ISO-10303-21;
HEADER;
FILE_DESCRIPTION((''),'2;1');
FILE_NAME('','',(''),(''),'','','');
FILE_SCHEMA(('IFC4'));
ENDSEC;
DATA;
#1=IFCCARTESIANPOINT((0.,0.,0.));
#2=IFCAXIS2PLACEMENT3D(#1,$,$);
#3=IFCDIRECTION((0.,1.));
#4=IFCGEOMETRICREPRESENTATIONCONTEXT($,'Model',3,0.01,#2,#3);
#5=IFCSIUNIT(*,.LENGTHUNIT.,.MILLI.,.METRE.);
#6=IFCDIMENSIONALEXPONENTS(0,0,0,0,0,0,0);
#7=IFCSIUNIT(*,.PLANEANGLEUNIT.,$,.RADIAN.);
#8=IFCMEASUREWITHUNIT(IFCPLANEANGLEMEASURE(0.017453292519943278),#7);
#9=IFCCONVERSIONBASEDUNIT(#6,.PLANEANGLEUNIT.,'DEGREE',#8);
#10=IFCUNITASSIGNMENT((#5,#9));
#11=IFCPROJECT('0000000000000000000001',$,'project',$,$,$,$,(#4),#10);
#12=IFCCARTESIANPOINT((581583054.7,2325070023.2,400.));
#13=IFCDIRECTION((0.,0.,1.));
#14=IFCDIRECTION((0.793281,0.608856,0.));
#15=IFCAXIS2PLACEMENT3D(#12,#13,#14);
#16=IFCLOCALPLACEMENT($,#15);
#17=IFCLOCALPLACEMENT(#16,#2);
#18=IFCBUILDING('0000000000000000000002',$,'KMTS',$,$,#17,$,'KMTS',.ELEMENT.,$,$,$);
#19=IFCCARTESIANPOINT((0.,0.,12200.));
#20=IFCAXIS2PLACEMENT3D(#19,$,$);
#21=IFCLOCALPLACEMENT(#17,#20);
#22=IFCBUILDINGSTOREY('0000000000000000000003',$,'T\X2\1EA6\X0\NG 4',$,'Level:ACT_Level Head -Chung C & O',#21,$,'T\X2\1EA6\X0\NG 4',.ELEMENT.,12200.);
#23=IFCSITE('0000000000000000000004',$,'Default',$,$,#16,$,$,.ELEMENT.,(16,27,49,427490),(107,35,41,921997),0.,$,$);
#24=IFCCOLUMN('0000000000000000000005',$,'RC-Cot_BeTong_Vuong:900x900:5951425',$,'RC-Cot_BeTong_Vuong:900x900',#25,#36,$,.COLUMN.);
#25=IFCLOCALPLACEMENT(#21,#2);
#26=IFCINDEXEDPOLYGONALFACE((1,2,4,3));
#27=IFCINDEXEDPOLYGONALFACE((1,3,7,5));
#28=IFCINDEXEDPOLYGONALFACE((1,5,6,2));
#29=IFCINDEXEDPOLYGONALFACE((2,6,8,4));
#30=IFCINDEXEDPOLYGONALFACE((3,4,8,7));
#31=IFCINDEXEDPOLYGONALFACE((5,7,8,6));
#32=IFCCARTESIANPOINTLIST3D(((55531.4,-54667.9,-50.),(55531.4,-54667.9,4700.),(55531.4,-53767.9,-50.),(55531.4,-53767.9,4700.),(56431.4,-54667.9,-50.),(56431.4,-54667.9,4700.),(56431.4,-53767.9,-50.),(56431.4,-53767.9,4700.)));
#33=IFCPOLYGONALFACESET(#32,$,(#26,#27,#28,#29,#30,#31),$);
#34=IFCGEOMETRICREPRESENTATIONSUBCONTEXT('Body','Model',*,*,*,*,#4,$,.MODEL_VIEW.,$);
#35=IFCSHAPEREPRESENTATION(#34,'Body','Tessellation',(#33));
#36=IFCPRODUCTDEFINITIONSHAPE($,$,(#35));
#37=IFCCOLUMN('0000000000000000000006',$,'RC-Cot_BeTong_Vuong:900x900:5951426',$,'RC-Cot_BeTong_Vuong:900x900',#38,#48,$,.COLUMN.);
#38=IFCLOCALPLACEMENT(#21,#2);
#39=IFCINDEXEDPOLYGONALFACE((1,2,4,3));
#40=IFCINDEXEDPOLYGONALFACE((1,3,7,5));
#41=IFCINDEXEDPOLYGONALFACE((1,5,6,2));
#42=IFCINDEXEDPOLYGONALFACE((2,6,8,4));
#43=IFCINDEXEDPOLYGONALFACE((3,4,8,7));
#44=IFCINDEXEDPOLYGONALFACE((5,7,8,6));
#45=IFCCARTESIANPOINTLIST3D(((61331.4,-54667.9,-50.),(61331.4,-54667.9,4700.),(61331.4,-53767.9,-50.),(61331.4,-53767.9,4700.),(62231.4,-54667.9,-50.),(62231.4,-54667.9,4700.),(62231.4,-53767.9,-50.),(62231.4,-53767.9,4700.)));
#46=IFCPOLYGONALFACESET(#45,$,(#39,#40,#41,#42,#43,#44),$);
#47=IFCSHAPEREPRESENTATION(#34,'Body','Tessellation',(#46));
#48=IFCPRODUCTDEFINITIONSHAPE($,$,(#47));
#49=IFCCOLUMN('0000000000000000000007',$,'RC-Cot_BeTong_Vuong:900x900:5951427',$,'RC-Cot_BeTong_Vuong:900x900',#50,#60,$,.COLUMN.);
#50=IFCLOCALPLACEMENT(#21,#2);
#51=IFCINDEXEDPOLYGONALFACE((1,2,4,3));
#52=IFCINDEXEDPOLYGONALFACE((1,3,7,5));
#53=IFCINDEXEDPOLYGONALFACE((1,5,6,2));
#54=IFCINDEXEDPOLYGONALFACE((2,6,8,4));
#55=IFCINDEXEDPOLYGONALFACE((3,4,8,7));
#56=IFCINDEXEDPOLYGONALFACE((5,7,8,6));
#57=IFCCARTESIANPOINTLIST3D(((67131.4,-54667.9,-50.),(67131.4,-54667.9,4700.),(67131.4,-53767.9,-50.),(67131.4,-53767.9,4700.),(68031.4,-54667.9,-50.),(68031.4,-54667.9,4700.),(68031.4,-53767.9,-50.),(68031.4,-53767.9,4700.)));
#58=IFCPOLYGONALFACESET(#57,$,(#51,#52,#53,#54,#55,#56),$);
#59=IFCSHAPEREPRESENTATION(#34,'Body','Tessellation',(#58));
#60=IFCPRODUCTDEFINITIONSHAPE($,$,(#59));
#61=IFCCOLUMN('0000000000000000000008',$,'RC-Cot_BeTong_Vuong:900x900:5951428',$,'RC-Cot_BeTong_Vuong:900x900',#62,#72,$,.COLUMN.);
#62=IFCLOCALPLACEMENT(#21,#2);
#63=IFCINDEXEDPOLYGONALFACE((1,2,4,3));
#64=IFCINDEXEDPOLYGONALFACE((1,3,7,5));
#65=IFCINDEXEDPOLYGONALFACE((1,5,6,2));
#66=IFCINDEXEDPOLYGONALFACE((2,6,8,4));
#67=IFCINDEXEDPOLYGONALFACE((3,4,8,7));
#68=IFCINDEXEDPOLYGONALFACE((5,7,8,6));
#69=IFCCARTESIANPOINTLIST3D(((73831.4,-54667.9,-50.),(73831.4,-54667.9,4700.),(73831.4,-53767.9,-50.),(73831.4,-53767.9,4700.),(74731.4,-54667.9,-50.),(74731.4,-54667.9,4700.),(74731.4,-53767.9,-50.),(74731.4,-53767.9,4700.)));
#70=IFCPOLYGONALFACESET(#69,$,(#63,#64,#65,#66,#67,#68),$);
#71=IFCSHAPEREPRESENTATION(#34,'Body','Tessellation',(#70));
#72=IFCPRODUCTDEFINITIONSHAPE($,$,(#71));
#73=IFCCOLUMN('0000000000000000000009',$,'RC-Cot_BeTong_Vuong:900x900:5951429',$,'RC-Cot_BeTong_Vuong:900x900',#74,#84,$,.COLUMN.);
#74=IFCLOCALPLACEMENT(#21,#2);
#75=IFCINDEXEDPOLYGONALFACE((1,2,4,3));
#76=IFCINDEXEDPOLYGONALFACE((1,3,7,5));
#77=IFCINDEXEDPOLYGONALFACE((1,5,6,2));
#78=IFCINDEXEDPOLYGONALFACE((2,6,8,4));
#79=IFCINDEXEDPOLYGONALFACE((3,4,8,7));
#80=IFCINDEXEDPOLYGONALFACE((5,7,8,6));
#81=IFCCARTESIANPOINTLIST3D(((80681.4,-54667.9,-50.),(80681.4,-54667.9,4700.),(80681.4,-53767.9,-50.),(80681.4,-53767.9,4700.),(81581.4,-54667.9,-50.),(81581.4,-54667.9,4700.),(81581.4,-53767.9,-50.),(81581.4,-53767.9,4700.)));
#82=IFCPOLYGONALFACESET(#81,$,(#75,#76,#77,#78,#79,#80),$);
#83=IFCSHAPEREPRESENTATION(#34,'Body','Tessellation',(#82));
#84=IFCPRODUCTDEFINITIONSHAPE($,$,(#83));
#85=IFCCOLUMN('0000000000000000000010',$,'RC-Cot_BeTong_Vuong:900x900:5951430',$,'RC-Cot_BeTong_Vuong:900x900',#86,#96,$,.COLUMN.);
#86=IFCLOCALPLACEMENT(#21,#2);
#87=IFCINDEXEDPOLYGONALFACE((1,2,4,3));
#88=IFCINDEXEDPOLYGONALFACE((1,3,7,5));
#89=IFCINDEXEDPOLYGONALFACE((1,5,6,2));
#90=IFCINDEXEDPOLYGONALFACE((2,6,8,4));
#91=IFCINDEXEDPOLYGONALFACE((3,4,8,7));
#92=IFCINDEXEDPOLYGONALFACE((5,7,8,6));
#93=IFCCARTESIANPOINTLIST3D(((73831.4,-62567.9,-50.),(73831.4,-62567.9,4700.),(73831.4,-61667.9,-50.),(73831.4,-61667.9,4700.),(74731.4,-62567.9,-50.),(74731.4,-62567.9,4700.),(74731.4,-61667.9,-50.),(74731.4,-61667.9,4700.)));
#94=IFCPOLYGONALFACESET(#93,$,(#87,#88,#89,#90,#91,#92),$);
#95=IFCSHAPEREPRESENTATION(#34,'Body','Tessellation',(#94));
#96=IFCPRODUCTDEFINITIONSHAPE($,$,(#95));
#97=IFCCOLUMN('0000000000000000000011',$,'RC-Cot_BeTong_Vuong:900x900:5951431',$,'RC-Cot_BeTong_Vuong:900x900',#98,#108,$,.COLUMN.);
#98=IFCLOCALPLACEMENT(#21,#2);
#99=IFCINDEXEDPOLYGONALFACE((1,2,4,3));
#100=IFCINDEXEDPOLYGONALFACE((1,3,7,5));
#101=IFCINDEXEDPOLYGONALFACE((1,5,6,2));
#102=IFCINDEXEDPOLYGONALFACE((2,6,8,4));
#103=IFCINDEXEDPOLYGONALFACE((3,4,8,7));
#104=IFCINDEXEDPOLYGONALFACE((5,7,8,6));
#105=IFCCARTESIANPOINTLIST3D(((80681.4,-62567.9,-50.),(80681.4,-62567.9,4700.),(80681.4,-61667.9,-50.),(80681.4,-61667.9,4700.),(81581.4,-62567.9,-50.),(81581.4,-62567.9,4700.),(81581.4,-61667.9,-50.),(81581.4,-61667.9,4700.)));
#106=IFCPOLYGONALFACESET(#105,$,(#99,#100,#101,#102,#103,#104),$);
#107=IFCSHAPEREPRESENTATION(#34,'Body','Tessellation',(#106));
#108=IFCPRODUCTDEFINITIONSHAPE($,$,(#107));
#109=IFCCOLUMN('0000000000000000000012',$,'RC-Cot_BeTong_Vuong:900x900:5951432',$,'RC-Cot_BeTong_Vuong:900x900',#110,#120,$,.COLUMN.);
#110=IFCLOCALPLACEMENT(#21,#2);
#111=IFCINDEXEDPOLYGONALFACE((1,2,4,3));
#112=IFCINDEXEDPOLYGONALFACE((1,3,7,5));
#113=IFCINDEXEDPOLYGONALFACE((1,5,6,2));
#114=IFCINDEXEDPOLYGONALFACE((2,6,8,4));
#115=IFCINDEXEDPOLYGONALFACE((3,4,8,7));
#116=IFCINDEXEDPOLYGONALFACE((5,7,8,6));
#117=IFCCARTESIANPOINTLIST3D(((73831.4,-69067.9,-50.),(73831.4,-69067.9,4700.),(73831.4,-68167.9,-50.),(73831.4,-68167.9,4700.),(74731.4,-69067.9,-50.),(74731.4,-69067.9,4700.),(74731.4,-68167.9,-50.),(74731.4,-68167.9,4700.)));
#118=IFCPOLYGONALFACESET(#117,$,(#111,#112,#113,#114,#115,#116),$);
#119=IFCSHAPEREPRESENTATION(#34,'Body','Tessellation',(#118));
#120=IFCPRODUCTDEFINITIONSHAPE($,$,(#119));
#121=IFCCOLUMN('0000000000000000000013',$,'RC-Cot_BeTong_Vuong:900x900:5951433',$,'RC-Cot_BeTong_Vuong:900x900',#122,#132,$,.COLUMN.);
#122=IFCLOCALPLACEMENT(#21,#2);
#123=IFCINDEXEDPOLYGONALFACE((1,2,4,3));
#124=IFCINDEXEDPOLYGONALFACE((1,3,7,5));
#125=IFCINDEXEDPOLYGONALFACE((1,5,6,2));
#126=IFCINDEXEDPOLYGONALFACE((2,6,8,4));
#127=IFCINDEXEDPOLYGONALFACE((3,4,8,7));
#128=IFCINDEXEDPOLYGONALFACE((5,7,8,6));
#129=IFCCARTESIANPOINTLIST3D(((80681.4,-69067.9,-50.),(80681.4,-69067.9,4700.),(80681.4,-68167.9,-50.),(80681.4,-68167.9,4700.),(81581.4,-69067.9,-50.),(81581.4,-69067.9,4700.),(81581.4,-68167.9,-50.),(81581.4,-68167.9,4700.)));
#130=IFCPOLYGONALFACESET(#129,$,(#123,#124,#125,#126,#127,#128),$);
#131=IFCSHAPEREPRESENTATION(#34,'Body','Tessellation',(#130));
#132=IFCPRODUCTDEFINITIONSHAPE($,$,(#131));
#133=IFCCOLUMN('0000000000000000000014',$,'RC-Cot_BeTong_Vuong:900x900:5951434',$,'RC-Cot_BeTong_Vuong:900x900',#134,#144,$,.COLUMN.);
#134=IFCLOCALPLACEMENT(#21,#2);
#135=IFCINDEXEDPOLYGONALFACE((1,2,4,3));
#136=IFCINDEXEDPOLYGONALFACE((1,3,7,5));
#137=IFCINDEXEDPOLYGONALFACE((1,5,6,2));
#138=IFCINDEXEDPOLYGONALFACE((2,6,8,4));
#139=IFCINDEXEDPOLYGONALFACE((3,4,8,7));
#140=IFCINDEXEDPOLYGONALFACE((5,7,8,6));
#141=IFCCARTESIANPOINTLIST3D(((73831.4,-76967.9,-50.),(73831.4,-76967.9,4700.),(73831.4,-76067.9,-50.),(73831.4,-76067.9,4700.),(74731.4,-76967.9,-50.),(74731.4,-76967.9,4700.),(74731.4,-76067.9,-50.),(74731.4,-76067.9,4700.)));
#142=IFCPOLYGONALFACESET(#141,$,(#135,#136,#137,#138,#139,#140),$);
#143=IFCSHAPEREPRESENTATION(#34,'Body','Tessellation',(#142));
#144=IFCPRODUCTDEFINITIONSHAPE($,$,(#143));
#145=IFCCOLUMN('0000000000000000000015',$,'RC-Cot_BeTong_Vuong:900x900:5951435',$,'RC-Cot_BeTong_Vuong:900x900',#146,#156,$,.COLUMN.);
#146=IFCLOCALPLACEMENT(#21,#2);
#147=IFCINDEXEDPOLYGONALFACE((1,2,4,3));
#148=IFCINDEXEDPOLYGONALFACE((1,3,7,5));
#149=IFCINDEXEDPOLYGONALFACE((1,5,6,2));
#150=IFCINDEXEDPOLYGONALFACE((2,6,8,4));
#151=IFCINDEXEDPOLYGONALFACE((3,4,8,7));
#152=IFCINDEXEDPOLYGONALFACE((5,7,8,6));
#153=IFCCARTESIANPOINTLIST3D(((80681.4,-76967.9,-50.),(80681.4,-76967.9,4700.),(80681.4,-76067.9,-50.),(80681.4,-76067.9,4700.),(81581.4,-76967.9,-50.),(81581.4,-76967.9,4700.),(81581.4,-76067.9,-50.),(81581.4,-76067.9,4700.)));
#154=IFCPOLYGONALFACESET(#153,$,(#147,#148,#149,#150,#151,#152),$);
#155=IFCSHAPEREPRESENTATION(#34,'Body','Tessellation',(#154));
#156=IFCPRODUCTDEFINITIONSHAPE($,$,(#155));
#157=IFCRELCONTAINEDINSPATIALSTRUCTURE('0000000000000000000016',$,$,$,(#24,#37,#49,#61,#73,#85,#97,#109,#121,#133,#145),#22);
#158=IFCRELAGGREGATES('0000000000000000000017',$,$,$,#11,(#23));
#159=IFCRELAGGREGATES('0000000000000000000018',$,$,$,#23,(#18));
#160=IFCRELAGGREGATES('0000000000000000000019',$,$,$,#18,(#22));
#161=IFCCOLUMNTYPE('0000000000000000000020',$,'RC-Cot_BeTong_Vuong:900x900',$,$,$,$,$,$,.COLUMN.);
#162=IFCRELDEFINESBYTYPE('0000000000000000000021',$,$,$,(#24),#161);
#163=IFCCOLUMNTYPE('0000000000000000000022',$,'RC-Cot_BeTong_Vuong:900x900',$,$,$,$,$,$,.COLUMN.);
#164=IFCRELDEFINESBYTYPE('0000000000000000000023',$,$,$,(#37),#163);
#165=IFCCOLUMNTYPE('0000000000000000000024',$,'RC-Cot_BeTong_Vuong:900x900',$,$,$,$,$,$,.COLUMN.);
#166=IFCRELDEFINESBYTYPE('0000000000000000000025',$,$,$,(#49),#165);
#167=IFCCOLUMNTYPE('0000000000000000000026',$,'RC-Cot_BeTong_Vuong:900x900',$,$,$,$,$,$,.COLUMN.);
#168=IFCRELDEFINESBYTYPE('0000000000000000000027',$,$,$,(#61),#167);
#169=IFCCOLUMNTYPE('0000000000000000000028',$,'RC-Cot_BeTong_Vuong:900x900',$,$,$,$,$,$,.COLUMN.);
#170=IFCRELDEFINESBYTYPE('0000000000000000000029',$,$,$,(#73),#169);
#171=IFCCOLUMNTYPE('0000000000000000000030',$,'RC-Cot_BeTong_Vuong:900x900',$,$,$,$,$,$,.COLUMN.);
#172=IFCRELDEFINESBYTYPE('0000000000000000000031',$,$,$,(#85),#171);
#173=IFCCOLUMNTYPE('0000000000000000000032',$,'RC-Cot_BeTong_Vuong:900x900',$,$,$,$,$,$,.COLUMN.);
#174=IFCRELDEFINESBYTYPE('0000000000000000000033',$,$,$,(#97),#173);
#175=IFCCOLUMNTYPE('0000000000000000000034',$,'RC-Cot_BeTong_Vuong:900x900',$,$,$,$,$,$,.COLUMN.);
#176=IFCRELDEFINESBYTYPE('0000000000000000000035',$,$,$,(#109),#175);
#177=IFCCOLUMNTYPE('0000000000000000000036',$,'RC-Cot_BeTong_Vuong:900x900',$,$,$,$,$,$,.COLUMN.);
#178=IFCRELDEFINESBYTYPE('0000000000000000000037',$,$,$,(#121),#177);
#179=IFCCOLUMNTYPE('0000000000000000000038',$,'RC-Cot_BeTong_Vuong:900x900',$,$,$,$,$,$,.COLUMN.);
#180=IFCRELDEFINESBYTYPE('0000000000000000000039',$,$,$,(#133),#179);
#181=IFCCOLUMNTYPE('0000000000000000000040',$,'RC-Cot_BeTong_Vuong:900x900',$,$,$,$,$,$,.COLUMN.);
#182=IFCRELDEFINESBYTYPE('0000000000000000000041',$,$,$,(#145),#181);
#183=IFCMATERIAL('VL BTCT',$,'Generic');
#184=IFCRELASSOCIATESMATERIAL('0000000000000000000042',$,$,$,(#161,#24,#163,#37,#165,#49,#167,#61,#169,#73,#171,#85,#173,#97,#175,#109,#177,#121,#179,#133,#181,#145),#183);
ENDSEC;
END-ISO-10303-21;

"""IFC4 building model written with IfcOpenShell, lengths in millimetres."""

from ifc_helpers import new_model, entity, si_unit, converted_unit, direction, frame, origin, place, context, subcontext, project, spatial, indexed_curve, outline, extrude, source, transform, mapped, material, type_object, type_shapes, element, save


model = new_model("IFC4")

# Units and contexts
model_context = context("Model", 3, precision=0.01, world=origin(), true_north=direction((0.0, 1.0)))
body_context = subcontext(model_context, "Body", "Model", "MODEL_VIEW")
ifc_project = project(units=[si_unit("LENGTHUNIT", "METRE", prefix="MILLI"), converted_unit("PLANEANGLEUNIT", "DEGREE", entity("IfcPlaneAngleMeasure", 0.017453292519943278), si_unit("PLANEANGLEUNIT", "RADIAN"), dimensions=[0, 0, 0, 0, 0, 0, 0])], contexts=[model_context])

# Site, building, storey
site_placement = place(None, frame((581583054.7, 2325070023.2, 400.0), z_axis=(0.0, 0.0, 1.0), x_axis=(0.793281, 0.608856, 0.0)))
site = spatial("IfcSite", under=ifc_project, at=site_placement, Name="Default", CompositionType="ELEMENT", RefLatitude=(16, 27, 49, 427490), RefLongitude=(107, 35, 41, 921997), RefElevation=0.0)
building_placement = place(site_placement, origin())
building = spatial("IfcBuilding", under=site, at=building_placement, Name="KMTS", LongName="KMTS", CompositionType="ELEMENT")
storey_placement = place(building_placement, frame((0.0, 0.0, 12200.0)))
storey = spatial("IfcBuildingStorey", under=building, at=storey_placement, Name="TẦNG 4", ObjectType="Level:ACT_Level Head -Chung C & O", LongName="TẦNG 4", CompositionType="ELEMENT", Elevation=12200.0)

# Columns
ifc_material_1 = material(Name="VL BTCT", Category="Generic")
column_type_1 = type_object("IfcColumnType", Name="RC-Cot_BeTong_Vuong:900x900", PredefinedType="COLUMN", material=ifc_material_1)
shared_shape_1 = source(origin(), body_context, "Body", "SweptSolid", [
    extrude(outline(indexed_curve([(-450.0, -450.0), (450.0, -450.0), (450.0, 450.0), (-450.0, 450.0), (-450.0, -450.0)], self_intersect=False)), frame((55981.4, -54217.9, 12150.0), z_axis=(0.0, 0.0, 1.0), x_axis=(-1.0, 0.0, 0.0)), (0.0, 0.0, 1.0), 4750.0),
])
type_shapes(column_type_1, [shared_shape_1])
column_1_placement = place(storey_placement, frame((0.0, 0.0, -12200.0)))
element("IfcColumn", 1, at=column_1_placement, inside=storey, type_object=column_type_1, material=ifc_material_1, Name="RC-Cot_BeTong_Vuong:900x900:5951425", ObjectType="RC-Cot_BeTong_Vuong:900x900", PredefinedType="COLUMN", context=body_context, shape_type="MappedRepresentation", body=[
    mapped(shared_shape_1, transform((0.0, 0.0, 0.0), scale=1.0)),
])
column_type_2 = type_object("IfcColumnType", Name="RC-Cot_BeTong_Vuong:900x900", PredefinedType="COLUMN", material=ifc_material_1)
shared_shape_2 = source(origin(), body_context, "Body", "SweptSolid", [
    extrude(outline(indexed_curve([(-450.0, -450.0), (450.0, -450.0), (450.0, 450.0), (-450.0, 450.0), (-450.0, -450.0)], self_intersect=False)), frame((61781.4, -54217.9, 12150.0), z_axis=(0.0, 0.0, 1.0), x_axis=(-1.0, 0.0, 0.0)), (0.0, 0.0, 1.0), 4750.0),
])
type_shapes(column_type_2, [shared_shape_2])
column_2_placement = place(storey_placement, frame((0.0, 0.0, -12200.0)))
element("IfcColumn", 2, at=column_2_placement, inside=storey, type_object=column_type_2, material=ifc_material_1, Name="RC-Cot_BeTong_Vuong:900x900:5951426", ObjectType="RC-Cot_BeTong_Vuong:900x900", PredefinedType="COLUMN", context=body_context, shape_type="MappedRepresentation", body=[
    mapped(shared_shape_2, transform((0.0, 0.0, 0.0), scale=1.0)),
])
column_type_3 = type_object("IfcColumnType", Name="RC-Cot_BeTong_Vuong:900x900", PredefinedType="COLUMN", material=ifc_material_1)
shared_shape_3 = source(origin(), body_context, "Body", "SweptSolid", [
    extrude(outline(indexed_curve([(-450.0, -450.0), (450.0, -450.0), (450.0, 450.0), (-450.0, 450.0), (-450.0, -450.0)], self_intersect=False)), frame((67581.4, -54217.9, 12150.0), z_axis=(0.0, 0.0, 1.0), x_axis=(-1.0, 0.0, 0.0)), (0.0, 0.0, 1.0), 4750.0),
])
type_shapes(column_type_3, [shared_shape_3])
column_3_placement = place(storey_placement, frame((0.0, 0.0, -12200.0)))
element("IfcColumn", 3, at=column_3_placement, inside=storey, type_object=column_type_3, material=ifc_material_1, Name="RC-Cot_BeTong_Vuong:900x900:5951427", ObjectType="RC-Cot_BeTong_Vuong:900x900", PredefinedType="COLUMN", context=body_context, shape_type="MappedRepresentation", body=[
    mapped(shared_shape_3, transform((0.0, 0.0, 0.0), scale=1.0)),
])
column_type_4 = type_object("IfcColumnType", Name="RC-Cot_BeTong_Vuong:900x900", PredefinedType="COLUMN", material=ifc_material_1)
shared_shape_4 = source(origin(), body_context, "Body", "SweptSolid", [
    extrude(outline(indexed_curve([(-450.0, -450.0), (450.0, -450.0), (450.0, 450.0), (-450.0, 450.0), (-450.0, -450.0)], self_intersect=False)), frame((74281.4, -54217.9, 12150.0), z_axis=(0.0, 0.0, 1.0), x_axis=(-1.0, 0.0, 0.0)), (0.0, 0.0, 1.0), 4750.0),
])
type_shapes(column_type_4, [shared_shape_4])
column_4_placement = place(storey_placement, frame((0.0, 0.0, -12200.0)))
element("IfcColumn", 4, at=column_4_placement, inside=storey, type_object=column_type_4, material=ifc_material_1, Name="RC-Cot_BeTong_Vuong:900x900:5951428", ObjectType="RC-Cot_BeTong_Vuong:900x900", PredefinedType="COLUMN", context=body_context, shape_type="MappedRepresentation", body=[
    mapped(shared_shape_4, transform((0.0, 0.0, 0.0), scale=1.0)),
])
column_type_5 = type_object("IfcColumnType", Name="RC-Cot_BeTong_Vuong:900x900", PredefinedType="COLUMN", material=ifc_material_1)
shared_shape_5 = source(origin(), body_context, "Body", "SweptSolid", [
    extrude(outline(indexed_curve([(-450.0, -450.0), (450.0, -450.0), (450.0, 450.0), (-450.0, 450.0), (-450.0, -450.0)], self_intersect=False)), frame((81131.4, -54217.9, 12150.0), z_axis=(0.0, 0.0, 1.0), x_axis=(-1.0, 0.0, 0.0)), (0.0, 0.0, 1.0), 4750.0),
])
type_shapes(column_type_5, [shared_shape_5])
column_5_placement = place(storey_placement, frame((0.0, 0.0, -12200.0)))
element("IfcColumn", 5, at=column_5_placement, inside=storey, type_object=column_type_5, material=ifc_material_1, Name="RC-Cot_BeTong_Vuong:900x900:5951429", ObjectType="RC-Cot_BeTong_Vuong:900x900", PredefinedType="COLUMN", context=body_context, shape_type="MappedRepresentation", body=[
    mapped(shared_shape_5, transform((0.0, 0.0, 0.0), scale=1.0)),
])
column_type_6 = type_object("IfcColumnType", Name="RC-Cot_BeTong_Vuong:900x900", PredefinedType="COLUMN", material=ifc_material_1)
shared_shape_6 = source(origin(), body_context, "Body", "SweptSolid", [
    extrude(outline(indexed_curve([(-450.0, -450.0), (450.0, -450.0), (450.0, 450.0), (-450.0, 450.0), (-450.0, -450.0)], self_intersect=False)), frame((74281.4, -62117.9, 12150.0), z_axis=(0.0, 0.0, 1.0), x_axis=(-1.0, 0.0, 0.0)), (0.0, 0.0, 1.0), 4750.0),
])
type_shapes(column_type_6, [shared_shape_6])
column_6_placement = place(storey_placement, frame((0.0, 0.0, -12200.0)))
element("IfcColumn", 6, at=column_6_placement, inside=storey, type_object=column_type_6, material=ifc_material_1, Name="RC-Cot_BeTong_Vuong:900x900:5951430", ObjectType="RC-Cot_BeTong_Vuong:900x900", PredefinedType="COLUMN", context=body_context, shape_type="MappedRepresentation", body=[
    mapped(shared_shape_6, transform((0.0, 0.0, 0.0), scale=1.0)),
])
column_type_7 = type_object("IfcColumnType", Name="RC-Cot_BeTong_Vuong:900x900", PredefinedType="COLUMN", material=ifc_material_1)
shared_shape_7 = source(origin(), body_context, "Body", "SweptSolid", [
    extrude(outline(indexed_curve([(-450.0, -450.0), (450.0, -450.0), (450.0, 450.0), (-450.0, 450.0), (-450.0, -450.0)], self_intersect=False)), frame((81131.4, -62117.9, 12150.0), z_axis=(0.0, 0.0, 1.0), x_axis=(-1.0, 0.0, 0.0)), (0.0, 0.0, 1.0), 4750.0),
])
type_shapes(column_type_7, [shared_shape_7])
column_7_placement = place(storey_placement, frame((0.0, 0.0, -12200.0)))
element("IfcColumn", 7, at=column_7_placement, inside=storey, type_object=column_type_7, material=ifc_material_1, Name="RC-Cot_BeTong_Vuong:900x900:5951431", ObjectType="RC-Cot_BeTong_Vuong:900x900", PredefinedType="COLUMN", context=body_context, shape_type="MappedRepresentation", body=[
    mapped(shared_shape_7, transform((0.0, 0.0, 0.0), scale=1.0)),
])
column_type_8 = type_object("IfcColumnType", Name="RC-Cot_BeTong_Vuong:900x900", PredefinedType="COLUMN", material=ifc_material_1)
shared_shape_8 = source(origin(), body_context, "Body", "SweptSolid", [
    extrude(outline(indexed_curve([(-450.0, -450.0), (450.0, -450.0), (450.0, 450.0), (-450.0, 450.0), (-450.0, -450.0)], self_intersect=False)), frame((74281.4, -68617.9, 12150.0), z_axis=(0.0, 0.0, 1.0), x_axis=(-1.0, 0.0, 0.0)), (0.0, 0.0, 1.0), 4750.0),
])
type_shapes(column_type_8, [shared_shape_8])
column_8_placement = place(storey_placement, frame((0.0, 0.0, -12200.0)))
element("IfcColumn", 8, at=column_8_placement, inside=storey, type_object=column_type_8, material=ifc_material_1, Name="RC-Cot_BeTong_Vuong:900x900:5951432", ObjectType="RC-Cot_BeTong_Vuong:900x900", PredefinedType="COLUMN", context=body_context, shape_type="MappedRepresentation", body=[
    mapped(shared_shape_8, transform((0.0, 0.0, 0.0), scale=1.0)),
])
column_type_9 = type_object("IfcColumnType", Name="RC-Cot_BeTong_Vuong:900x900", PredefinedType="COLUMN", material=ifc_material_1)
shared_shape_9 = source(origin(), body_context, "Body", "SweptSolid", [
    extrude(outline(indexed_curve([(-450.0, -450.0), (450.0, -450.0), (450.0, 450.0), (-450.0, 450.0), (-450.0, -450.0)], self_intersect=False)), frame((81131.4, -68617.9, 12150.0), z_axis=(0.0, 0.0, 1.0), x_axis=(-1.0, 0.0, 0.0)), (0.0, 0.0, 1.0), 4750.0),
])
type_shapes(column_type_9, [shared_shape_9])
column_9_placement = place(storey_placement, frame((0.0, 0.0, -12200.0)))
element("IfcColumn", 9, at=column_9_placement, inside=storey, type_object=column_type_9, material=ifc_material_1, Name="RC-Cot_BeTong_Vuong:900x900:5951433", ObjectType="RC-Cot_BeTong_Vuong:900x900", PredefinedType="COLUMN", context=body_context, shape_type="MappedRepresentation", body=[
    mapped(shared_shape_9, transform((0.0, 0.0, 0.0), scale=1.0)),
])
column_type_10 = type_object("IfcColumnType", Name="RC-Cot_BeTong_Vuong:900x900", PredefinedType="COLUMN", material=ifc_material_1)
shared_shape_10 = source(origin(), body_context, "Body", "SweptSolid", [
    extrude(outline(indexed_curve([(-450.0, -450.0), (450.0, -450.0), (450.0, 450.0), (-450.0, 450.0), (-450.0, -450.0)], self_intersect=False)), frame((74281.4, -76517.9, 12150.0), z_axis=(0.0, 0.0, 1.0), x_axis=(-1.0, 0.0, 0.0)), (0.0, 0.0, 1.0), 4750.0),
])
type_shapes(column_type_10, [shared_shape_10])
column_10_placement = place(storey_placement, frame((0.0, 0.0, -12200.0)))
element("IfcColumn", 10, at=column_10_placement, inside=storey, type_object=column_type_10, material=ifc_material_1, Name="RC-Cot_BeTong_Vuong:900x900:5951434", ObjectType="RC-Cot_BeTong_Vuong:900x900", PredefinedType="COLUMN", context=body_context, shape_type="MappedRepresentation", body=[
    mapped(shared_shape_10, transform((0.0, 0.0, 0.0), scale=1.0)),
])
column_type_11 = type_object("IfcColumnType", Name="RC-Cot_BeTong_Vuong:900x900", PredefinedType="COLUMN", material=ifc_material_1)
shared_shape_11 = source(origin(), body_context, "Body", "SweptSolid", [
    extrude(outline(indexed_curve([(-450.0, -450.0), (450.0, -450.0), (450.0, 450.0), (-450.0, 450.0), (-450.0, -450.0)], self_intersect=False)), frame((81131.4, -76517.9, 12150.0), z_axis=(0.0, 0.0, 1.0), x_axis=(-1.0, 0.0, 0.0)), (0.0, 0.0, 1.0), 4750.0),
])
type_shapes(column_type_11, [shared_shape_11])
column_11_placement = place(storey_placement, frame((0.0, 0.0, -12200.0)))
element("IfcColumn", 11, at=column_11_placement, inside=storey, type_object=column_type_11, material=ifc_material_1, Name="RC-Cot_BeTong_Vuong:900x900:5951435", ObjectType="RC-Cot_BeTong_Vuong:900x900", PredefinedType="COLUMN", context=body_context, shape_type="MappedRepresentation", body=[
    mapped(shared_shape_11, transform((0.0, 0.0, 0.0), scale=1.0)),
])

save(model, "model.ifc")
